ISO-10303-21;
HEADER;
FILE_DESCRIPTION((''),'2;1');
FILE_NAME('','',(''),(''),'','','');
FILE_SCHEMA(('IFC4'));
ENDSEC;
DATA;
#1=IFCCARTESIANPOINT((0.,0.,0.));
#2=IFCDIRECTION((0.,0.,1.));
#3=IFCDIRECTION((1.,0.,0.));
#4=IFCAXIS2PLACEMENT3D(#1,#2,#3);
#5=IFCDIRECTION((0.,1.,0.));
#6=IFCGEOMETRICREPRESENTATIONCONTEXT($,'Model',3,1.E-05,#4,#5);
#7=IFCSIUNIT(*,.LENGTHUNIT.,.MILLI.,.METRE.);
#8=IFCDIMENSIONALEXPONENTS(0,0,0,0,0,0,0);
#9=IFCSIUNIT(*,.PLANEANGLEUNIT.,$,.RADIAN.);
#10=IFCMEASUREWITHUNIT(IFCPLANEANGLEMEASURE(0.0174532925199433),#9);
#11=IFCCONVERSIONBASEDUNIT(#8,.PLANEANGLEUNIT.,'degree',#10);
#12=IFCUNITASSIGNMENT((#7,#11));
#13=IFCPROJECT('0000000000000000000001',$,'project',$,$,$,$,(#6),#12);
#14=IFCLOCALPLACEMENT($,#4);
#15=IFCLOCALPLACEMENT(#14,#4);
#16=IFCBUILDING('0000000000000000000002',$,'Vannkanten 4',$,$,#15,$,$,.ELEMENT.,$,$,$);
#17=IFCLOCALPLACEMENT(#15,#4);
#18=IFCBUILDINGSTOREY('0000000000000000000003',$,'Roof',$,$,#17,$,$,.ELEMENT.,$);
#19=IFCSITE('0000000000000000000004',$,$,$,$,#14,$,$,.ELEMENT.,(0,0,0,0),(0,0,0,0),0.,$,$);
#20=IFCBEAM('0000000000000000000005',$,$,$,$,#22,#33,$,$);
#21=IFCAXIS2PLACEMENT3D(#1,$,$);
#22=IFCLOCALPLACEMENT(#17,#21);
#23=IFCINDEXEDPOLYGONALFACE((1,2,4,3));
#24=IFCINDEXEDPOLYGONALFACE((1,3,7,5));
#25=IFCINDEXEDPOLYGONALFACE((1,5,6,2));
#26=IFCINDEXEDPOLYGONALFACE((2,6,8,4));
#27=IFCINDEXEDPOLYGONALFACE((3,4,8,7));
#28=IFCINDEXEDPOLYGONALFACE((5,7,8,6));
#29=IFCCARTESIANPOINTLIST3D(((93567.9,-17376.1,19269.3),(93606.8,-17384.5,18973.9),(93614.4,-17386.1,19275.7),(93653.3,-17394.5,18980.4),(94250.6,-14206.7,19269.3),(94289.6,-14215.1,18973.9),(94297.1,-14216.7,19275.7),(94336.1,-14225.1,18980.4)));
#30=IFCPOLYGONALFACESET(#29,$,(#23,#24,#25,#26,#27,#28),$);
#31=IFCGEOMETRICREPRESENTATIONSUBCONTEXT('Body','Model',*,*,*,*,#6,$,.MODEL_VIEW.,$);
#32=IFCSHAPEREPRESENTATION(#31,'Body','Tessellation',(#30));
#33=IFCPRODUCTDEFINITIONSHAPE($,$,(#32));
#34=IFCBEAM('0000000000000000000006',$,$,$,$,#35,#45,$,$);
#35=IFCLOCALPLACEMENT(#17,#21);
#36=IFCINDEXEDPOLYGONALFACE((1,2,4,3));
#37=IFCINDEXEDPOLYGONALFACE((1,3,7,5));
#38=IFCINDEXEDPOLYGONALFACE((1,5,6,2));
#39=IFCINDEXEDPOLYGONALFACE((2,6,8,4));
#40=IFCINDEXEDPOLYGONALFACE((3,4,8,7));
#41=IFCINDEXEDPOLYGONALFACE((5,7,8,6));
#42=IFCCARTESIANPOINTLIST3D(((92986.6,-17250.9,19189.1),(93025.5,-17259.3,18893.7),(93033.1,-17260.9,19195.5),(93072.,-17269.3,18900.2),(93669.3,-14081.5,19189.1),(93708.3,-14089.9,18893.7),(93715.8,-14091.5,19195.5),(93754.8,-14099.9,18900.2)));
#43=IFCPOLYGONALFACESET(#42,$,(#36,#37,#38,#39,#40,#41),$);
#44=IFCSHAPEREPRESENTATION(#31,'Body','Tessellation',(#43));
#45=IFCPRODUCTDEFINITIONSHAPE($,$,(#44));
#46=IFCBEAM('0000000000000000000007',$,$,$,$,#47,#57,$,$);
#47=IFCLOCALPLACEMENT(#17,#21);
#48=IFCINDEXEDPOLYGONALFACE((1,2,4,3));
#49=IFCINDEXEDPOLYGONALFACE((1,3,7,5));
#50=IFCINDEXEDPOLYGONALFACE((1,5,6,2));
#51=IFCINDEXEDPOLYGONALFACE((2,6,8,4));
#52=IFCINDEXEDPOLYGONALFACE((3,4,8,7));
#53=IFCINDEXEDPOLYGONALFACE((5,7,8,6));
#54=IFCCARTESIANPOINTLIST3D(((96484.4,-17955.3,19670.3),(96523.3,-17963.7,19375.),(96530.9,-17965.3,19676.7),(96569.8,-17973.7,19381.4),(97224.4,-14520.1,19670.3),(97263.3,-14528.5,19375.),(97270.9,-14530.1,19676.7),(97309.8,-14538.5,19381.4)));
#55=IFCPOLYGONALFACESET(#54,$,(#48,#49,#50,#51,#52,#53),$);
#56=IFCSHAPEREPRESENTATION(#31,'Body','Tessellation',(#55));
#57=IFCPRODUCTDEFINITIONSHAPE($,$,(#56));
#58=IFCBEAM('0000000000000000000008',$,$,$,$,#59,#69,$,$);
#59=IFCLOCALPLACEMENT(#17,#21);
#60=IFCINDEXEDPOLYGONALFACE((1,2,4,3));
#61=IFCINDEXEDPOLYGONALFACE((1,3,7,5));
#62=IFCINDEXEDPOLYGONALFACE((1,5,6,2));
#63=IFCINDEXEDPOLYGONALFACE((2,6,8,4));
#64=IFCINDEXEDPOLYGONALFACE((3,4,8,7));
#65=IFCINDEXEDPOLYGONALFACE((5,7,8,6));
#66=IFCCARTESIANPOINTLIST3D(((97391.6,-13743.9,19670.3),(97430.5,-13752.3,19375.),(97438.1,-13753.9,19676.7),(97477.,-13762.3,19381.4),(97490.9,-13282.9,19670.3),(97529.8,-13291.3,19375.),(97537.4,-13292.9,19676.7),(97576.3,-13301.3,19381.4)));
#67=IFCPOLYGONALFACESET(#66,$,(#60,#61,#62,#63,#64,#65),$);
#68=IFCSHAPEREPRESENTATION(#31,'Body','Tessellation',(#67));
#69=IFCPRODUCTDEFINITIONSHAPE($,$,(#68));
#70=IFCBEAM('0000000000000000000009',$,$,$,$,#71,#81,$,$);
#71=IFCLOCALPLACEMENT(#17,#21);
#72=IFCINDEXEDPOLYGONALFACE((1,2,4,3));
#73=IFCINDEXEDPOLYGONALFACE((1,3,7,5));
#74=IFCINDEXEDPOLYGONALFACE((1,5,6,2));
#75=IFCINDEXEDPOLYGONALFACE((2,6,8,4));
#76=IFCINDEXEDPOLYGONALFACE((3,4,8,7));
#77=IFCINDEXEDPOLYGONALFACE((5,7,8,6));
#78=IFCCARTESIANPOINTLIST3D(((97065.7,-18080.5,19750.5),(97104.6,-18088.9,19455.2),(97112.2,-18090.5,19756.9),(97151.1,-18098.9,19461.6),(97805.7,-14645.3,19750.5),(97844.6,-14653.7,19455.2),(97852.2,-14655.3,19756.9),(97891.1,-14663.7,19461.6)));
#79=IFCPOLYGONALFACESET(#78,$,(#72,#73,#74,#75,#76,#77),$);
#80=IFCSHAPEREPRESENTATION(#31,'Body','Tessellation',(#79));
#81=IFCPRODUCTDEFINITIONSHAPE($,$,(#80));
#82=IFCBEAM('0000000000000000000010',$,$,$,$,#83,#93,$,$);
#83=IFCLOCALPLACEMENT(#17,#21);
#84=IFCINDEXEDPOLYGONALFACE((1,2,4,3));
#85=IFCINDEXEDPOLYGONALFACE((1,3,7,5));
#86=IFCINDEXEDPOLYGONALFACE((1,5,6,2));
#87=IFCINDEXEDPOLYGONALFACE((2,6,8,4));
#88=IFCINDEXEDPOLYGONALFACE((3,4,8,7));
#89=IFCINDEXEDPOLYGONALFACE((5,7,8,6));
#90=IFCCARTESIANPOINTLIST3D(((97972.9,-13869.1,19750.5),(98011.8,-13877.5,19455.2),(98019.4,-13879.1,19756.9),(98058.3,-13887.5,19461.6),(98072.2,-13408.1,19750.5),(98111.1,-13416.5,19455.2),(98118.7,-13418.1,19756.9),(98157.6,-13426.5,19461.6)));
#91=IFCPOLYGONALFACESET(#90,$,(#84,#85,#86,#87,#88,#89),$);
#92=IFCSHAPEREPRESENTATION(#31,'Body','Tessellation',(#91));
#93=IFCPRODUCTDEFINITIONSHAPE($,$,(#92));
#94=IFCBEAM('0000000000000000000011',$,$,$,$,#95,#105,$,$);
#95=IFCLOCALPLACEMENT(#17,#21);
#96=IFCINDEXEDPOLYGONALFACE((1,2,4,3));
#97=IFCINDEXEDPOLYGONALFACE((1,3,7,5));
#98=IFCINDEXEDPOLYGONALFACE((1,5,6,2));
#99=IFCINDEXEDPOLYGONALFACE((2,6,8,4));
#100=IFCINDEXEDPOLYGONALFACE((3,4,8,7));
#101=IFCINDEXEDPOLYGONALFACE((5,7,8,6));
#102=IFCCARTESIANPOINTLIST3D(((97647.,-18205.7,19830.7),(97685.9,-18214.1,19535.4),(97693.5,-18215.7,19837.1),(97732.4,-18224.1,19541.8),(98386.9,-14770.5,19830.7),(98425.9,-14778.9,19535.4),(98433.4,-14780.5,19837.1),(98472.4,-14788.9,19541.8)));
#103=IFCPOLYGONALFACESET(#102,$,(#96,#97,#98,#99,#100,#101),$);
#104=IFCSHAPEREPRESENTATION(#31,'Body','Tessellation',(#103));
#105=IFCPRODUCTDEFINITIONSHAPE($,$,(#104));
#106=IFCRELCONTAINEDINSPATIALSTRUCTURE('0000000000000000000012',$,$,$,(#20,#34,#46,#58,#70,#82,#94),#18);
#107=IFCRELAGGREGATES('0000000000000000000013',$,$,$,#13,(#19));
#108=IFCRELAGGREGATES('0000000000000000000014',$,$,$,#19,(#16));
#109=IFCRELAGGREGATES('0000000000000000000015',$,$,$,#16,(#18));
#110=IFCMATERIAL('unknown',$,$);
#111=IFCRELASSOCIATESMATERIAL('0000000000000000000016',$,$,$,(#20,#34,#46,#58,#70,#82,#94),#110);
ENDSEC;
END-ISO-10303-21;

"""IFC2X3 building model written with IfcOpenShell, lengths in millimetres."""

from ifc_helpers import new_model, entity, si_unit, converted_unit, direction, frame, origin_with_axes, place, context, subcontext, project, spatial, polyline, segment, composite_curve, outline, extrude, material, element, save


model = new_model("IFC2X3")

# Units and contexts
model_context = context("Model", 3, precision=1e-05, world=origin_with_axes(), true_north=direction((0.0, 1.0, 0.0)))
body_context = subcontext(model_context, "Body", "Model", "MODEL_VIEW")
ifc_project = project(units=[si_unit("LENGTHUNIT", "METRE", prefix="MILLI"), converted_unit("PLANEANGLEUNIT", "degree", entity("IfcPlaneAngleMeasure", 0.0174532925199433), si_unit("PLANEANGLEUNIT", "RADIAN"), dimensions=[0, 0, 0, 0, 0, 0, 0])], contexts=[model_context])

# Site, building, storey
site_placement = place(None, origin_with_axes())
site = spatial("IfcSite", under=ifc_project, at=site_placement, CompositionType="ELEMENT", RefLatitude=(0, 0, 0, 0), RefLongitude=(0, 0, 0, 0), RefElevation=0.0)
building_placement = place(site_placement, origin_with_axes())
building = spatial("IfcBuilding", under=site, at=building_placement, Name="Vannkanten 4", CompositionType="ELEMENT")
storey_placement = place(building_placement, origin_with_axes())
storey = spatial("IfcBuildingStorey", under=building, at=storey_placement, Name="Roof", CompositionType="ELEMENT")

# Shared definitions
ifc_material = material(Name="unknown")

# Beams
beam_1_placement = place(storey_placement, frame((93610.6, -17385.3, 19124.8), z_axis=(0.210582, 0.977576, 0.0), x_axis=(-0.968803, 0.208692, -0.133675)))
element("IfcBeam", 1, at=beam_1_placement, inside=storey, material=ifc_material, context=body_context, shape_type="SweptSolid", body=[
    extrude(outline(composite_curve([segment(polyline([(-24.0, -149.0), (-24.0, 149.0), (24.0, 149.0), (24.0, -149.0), (-24.0, -149.0)]), True, "CONTINUOUS")], self_intersect=False)), frame((0.0, 0.0, 0.0), z_axis=(0.0, 0.0, 1.0), x_axis=(1.0, 0.0, 0.0)), (0.0, 0.0, 1.0), 3242.2),
])
beam_2_placement = place(storey_placement, frame((93029.3, -17260.1, 19044.6), z_axis=(0.210582, 0.977576, 0.0), x_axis=(-0.968803, 0.208692, -0.133675)))
element("IfcBeam", 2, at=beam_2_placement, inside=storey, material=ifc_material, context=body_context, shape_type="SweptSolid", body=[
    extrude(outline(composite_curve([segment(polyline([(-24.0, -149.0), (-24.0, 149.0), (24.0, 149.0), (24.0, -149.0), (-24.0, -149.0)]), True, "CONTINUOUS")], self_intersect=False)), frame((0.0, 0.0, 0.0), z_axis=(0.0, 0.0, 1.0), x_axis=(1.0, 0.0, 0.0)), (0.0, 0.0, 1.0), 3242.2),
])
beam_3_placement = place(storey_placement, frame((96527.1, -17964.5, 19525.8), z_axis=(0.210582, 0.977576, 0.0), x_axis=(-0.968803, 0.208692, -0.133675)))
element("IfcBeam", 3, at=beam_3_placement, inside=storey, material=ifc_material, context=body_context, shape_type="SweptSolid", body=[
    extrude(outline(composite_curve([segment(polyline([(-24.0, -149.0), (-24.0, 149.0), (24.0, 149.0), (24.0, -149.0), (-24.0, -149.0)]), True, "CONTINUOUS")], self_intersect=False)), frame((0.0, 0.0, 0.0), z_axis=(0.0, 0.0, 1.0), x_axis=(1.0, 0.0, 0.0)), (0.0, 0.0, 1.0), 3514.0),
])
beam_4_placement = place(storey_placement, frame((97434.3, -13753.1, 19525.8), z_axis=(0.210582, 0.977576, 0.0), x_axis=(-0.968803, 0.208692, -0.133675)))
element("IfcBeam", 4, at=beam_4_placement, inside=storey, material=ifc_material, context=body_context, shape_type="SweptSolid", body=[
    extrude(outline(composite_curve([segment(polyline([(-24.0, -149.0), (-24.0, 149.0), (24.0, 149.0), (24.0, -149.0), (-24.0, -149.0)]), True, "CONTINUOUS")], self_intersect=False)), frame((0.0, 0.0, 0.0), z_axis=(0.0, 0.0, 1.0), x_axis=(1.0, 0.0, 0.0)), (0.0, 0.0, 1.0), 471.5),
])
beam_5_placement = place(storey_placement, frame((97108.4, -18089.7, 19606.0), z_axis=(0.210582, 0.977576, 0.0), x_axis=(-0.968803, 0.208692, -0.133675)))
element("IfcBeam", 5, at=beam_5_placement, inside=storey, material=ifc_material, context=body_context, shape_type="SweptSolid", body=[
    extrude(outline(composite_curve([segment(polyline([(-24.0, -149.0), (-24.0, 149.0), (24.0, 149.0), (24.0, -149.0), (-24.0, -149.0)]), True, "CONTINUOUS")], self_intersect=False)), frame((0.0, 0.0, 0.0), z_axis=(0.0, 0.0, 1.0), x_axis=(1.0, 0.0, 0.0)), (0.0, 0.0, 1.0), 3514.0),
])
beam_6_placement = place(storey_placement, frame((98015.6, -13878.3, 19606.0), z_axis=(0.210582, 0.977576, 0.0), x_axis=(-0.968803, 0.208692, -0.133675)))
element("IfcBeam", 6, at=beam_6_placement, inside=storey, material=ifc_material, context=body_context, shape_type="SweptSolid", body=[
    extrude(outline(composite_curve([segment(polyline([(-24.0, -149.0), (-24.0, 149.0), (24.0, 149.0), (24.0, -149.0), (-24.0, -149.0)]), True, "CONTINUOUS")], self_intersect=False)), frame((0.0, 0.0, 0.0), z_axis=(0.0, 0.0, 1.0), x_axis=(1.0, 0.0, 0.0)), (0.0, 0.0, 1.0), 471.5),
])
beam_7_placement = place(storey_placement, frame((97689.7, -18214.9, 19686.2), z_axis=(0.210582, 0.977576, 0.0), x_axis=(-0.968803, 0.208692, -0.133675)))
element("IfcBeam", 7, at=beam_7_placement, inside=storey, material=ifc_material, context=body_context, shape_type="SweptSolid", body=[
    extrude(outline(composite_curve([segment(polyline([(-24.0, -149.0), (-24.0, 149.0), (24.0, 149.0), (24.0, -149.0), (-24.0, -149.0)]), True, "CONTINUOUS")], self_intersect=False)), frame((0.0, 0.0, 0.0), z_axis=(0.0, 0.0, 1.0), x_axis=(1.0, 0.0, 0.0)), (0.0, 0.0, 1.0), 3514.0),
])

save(model, "model.ifc")
